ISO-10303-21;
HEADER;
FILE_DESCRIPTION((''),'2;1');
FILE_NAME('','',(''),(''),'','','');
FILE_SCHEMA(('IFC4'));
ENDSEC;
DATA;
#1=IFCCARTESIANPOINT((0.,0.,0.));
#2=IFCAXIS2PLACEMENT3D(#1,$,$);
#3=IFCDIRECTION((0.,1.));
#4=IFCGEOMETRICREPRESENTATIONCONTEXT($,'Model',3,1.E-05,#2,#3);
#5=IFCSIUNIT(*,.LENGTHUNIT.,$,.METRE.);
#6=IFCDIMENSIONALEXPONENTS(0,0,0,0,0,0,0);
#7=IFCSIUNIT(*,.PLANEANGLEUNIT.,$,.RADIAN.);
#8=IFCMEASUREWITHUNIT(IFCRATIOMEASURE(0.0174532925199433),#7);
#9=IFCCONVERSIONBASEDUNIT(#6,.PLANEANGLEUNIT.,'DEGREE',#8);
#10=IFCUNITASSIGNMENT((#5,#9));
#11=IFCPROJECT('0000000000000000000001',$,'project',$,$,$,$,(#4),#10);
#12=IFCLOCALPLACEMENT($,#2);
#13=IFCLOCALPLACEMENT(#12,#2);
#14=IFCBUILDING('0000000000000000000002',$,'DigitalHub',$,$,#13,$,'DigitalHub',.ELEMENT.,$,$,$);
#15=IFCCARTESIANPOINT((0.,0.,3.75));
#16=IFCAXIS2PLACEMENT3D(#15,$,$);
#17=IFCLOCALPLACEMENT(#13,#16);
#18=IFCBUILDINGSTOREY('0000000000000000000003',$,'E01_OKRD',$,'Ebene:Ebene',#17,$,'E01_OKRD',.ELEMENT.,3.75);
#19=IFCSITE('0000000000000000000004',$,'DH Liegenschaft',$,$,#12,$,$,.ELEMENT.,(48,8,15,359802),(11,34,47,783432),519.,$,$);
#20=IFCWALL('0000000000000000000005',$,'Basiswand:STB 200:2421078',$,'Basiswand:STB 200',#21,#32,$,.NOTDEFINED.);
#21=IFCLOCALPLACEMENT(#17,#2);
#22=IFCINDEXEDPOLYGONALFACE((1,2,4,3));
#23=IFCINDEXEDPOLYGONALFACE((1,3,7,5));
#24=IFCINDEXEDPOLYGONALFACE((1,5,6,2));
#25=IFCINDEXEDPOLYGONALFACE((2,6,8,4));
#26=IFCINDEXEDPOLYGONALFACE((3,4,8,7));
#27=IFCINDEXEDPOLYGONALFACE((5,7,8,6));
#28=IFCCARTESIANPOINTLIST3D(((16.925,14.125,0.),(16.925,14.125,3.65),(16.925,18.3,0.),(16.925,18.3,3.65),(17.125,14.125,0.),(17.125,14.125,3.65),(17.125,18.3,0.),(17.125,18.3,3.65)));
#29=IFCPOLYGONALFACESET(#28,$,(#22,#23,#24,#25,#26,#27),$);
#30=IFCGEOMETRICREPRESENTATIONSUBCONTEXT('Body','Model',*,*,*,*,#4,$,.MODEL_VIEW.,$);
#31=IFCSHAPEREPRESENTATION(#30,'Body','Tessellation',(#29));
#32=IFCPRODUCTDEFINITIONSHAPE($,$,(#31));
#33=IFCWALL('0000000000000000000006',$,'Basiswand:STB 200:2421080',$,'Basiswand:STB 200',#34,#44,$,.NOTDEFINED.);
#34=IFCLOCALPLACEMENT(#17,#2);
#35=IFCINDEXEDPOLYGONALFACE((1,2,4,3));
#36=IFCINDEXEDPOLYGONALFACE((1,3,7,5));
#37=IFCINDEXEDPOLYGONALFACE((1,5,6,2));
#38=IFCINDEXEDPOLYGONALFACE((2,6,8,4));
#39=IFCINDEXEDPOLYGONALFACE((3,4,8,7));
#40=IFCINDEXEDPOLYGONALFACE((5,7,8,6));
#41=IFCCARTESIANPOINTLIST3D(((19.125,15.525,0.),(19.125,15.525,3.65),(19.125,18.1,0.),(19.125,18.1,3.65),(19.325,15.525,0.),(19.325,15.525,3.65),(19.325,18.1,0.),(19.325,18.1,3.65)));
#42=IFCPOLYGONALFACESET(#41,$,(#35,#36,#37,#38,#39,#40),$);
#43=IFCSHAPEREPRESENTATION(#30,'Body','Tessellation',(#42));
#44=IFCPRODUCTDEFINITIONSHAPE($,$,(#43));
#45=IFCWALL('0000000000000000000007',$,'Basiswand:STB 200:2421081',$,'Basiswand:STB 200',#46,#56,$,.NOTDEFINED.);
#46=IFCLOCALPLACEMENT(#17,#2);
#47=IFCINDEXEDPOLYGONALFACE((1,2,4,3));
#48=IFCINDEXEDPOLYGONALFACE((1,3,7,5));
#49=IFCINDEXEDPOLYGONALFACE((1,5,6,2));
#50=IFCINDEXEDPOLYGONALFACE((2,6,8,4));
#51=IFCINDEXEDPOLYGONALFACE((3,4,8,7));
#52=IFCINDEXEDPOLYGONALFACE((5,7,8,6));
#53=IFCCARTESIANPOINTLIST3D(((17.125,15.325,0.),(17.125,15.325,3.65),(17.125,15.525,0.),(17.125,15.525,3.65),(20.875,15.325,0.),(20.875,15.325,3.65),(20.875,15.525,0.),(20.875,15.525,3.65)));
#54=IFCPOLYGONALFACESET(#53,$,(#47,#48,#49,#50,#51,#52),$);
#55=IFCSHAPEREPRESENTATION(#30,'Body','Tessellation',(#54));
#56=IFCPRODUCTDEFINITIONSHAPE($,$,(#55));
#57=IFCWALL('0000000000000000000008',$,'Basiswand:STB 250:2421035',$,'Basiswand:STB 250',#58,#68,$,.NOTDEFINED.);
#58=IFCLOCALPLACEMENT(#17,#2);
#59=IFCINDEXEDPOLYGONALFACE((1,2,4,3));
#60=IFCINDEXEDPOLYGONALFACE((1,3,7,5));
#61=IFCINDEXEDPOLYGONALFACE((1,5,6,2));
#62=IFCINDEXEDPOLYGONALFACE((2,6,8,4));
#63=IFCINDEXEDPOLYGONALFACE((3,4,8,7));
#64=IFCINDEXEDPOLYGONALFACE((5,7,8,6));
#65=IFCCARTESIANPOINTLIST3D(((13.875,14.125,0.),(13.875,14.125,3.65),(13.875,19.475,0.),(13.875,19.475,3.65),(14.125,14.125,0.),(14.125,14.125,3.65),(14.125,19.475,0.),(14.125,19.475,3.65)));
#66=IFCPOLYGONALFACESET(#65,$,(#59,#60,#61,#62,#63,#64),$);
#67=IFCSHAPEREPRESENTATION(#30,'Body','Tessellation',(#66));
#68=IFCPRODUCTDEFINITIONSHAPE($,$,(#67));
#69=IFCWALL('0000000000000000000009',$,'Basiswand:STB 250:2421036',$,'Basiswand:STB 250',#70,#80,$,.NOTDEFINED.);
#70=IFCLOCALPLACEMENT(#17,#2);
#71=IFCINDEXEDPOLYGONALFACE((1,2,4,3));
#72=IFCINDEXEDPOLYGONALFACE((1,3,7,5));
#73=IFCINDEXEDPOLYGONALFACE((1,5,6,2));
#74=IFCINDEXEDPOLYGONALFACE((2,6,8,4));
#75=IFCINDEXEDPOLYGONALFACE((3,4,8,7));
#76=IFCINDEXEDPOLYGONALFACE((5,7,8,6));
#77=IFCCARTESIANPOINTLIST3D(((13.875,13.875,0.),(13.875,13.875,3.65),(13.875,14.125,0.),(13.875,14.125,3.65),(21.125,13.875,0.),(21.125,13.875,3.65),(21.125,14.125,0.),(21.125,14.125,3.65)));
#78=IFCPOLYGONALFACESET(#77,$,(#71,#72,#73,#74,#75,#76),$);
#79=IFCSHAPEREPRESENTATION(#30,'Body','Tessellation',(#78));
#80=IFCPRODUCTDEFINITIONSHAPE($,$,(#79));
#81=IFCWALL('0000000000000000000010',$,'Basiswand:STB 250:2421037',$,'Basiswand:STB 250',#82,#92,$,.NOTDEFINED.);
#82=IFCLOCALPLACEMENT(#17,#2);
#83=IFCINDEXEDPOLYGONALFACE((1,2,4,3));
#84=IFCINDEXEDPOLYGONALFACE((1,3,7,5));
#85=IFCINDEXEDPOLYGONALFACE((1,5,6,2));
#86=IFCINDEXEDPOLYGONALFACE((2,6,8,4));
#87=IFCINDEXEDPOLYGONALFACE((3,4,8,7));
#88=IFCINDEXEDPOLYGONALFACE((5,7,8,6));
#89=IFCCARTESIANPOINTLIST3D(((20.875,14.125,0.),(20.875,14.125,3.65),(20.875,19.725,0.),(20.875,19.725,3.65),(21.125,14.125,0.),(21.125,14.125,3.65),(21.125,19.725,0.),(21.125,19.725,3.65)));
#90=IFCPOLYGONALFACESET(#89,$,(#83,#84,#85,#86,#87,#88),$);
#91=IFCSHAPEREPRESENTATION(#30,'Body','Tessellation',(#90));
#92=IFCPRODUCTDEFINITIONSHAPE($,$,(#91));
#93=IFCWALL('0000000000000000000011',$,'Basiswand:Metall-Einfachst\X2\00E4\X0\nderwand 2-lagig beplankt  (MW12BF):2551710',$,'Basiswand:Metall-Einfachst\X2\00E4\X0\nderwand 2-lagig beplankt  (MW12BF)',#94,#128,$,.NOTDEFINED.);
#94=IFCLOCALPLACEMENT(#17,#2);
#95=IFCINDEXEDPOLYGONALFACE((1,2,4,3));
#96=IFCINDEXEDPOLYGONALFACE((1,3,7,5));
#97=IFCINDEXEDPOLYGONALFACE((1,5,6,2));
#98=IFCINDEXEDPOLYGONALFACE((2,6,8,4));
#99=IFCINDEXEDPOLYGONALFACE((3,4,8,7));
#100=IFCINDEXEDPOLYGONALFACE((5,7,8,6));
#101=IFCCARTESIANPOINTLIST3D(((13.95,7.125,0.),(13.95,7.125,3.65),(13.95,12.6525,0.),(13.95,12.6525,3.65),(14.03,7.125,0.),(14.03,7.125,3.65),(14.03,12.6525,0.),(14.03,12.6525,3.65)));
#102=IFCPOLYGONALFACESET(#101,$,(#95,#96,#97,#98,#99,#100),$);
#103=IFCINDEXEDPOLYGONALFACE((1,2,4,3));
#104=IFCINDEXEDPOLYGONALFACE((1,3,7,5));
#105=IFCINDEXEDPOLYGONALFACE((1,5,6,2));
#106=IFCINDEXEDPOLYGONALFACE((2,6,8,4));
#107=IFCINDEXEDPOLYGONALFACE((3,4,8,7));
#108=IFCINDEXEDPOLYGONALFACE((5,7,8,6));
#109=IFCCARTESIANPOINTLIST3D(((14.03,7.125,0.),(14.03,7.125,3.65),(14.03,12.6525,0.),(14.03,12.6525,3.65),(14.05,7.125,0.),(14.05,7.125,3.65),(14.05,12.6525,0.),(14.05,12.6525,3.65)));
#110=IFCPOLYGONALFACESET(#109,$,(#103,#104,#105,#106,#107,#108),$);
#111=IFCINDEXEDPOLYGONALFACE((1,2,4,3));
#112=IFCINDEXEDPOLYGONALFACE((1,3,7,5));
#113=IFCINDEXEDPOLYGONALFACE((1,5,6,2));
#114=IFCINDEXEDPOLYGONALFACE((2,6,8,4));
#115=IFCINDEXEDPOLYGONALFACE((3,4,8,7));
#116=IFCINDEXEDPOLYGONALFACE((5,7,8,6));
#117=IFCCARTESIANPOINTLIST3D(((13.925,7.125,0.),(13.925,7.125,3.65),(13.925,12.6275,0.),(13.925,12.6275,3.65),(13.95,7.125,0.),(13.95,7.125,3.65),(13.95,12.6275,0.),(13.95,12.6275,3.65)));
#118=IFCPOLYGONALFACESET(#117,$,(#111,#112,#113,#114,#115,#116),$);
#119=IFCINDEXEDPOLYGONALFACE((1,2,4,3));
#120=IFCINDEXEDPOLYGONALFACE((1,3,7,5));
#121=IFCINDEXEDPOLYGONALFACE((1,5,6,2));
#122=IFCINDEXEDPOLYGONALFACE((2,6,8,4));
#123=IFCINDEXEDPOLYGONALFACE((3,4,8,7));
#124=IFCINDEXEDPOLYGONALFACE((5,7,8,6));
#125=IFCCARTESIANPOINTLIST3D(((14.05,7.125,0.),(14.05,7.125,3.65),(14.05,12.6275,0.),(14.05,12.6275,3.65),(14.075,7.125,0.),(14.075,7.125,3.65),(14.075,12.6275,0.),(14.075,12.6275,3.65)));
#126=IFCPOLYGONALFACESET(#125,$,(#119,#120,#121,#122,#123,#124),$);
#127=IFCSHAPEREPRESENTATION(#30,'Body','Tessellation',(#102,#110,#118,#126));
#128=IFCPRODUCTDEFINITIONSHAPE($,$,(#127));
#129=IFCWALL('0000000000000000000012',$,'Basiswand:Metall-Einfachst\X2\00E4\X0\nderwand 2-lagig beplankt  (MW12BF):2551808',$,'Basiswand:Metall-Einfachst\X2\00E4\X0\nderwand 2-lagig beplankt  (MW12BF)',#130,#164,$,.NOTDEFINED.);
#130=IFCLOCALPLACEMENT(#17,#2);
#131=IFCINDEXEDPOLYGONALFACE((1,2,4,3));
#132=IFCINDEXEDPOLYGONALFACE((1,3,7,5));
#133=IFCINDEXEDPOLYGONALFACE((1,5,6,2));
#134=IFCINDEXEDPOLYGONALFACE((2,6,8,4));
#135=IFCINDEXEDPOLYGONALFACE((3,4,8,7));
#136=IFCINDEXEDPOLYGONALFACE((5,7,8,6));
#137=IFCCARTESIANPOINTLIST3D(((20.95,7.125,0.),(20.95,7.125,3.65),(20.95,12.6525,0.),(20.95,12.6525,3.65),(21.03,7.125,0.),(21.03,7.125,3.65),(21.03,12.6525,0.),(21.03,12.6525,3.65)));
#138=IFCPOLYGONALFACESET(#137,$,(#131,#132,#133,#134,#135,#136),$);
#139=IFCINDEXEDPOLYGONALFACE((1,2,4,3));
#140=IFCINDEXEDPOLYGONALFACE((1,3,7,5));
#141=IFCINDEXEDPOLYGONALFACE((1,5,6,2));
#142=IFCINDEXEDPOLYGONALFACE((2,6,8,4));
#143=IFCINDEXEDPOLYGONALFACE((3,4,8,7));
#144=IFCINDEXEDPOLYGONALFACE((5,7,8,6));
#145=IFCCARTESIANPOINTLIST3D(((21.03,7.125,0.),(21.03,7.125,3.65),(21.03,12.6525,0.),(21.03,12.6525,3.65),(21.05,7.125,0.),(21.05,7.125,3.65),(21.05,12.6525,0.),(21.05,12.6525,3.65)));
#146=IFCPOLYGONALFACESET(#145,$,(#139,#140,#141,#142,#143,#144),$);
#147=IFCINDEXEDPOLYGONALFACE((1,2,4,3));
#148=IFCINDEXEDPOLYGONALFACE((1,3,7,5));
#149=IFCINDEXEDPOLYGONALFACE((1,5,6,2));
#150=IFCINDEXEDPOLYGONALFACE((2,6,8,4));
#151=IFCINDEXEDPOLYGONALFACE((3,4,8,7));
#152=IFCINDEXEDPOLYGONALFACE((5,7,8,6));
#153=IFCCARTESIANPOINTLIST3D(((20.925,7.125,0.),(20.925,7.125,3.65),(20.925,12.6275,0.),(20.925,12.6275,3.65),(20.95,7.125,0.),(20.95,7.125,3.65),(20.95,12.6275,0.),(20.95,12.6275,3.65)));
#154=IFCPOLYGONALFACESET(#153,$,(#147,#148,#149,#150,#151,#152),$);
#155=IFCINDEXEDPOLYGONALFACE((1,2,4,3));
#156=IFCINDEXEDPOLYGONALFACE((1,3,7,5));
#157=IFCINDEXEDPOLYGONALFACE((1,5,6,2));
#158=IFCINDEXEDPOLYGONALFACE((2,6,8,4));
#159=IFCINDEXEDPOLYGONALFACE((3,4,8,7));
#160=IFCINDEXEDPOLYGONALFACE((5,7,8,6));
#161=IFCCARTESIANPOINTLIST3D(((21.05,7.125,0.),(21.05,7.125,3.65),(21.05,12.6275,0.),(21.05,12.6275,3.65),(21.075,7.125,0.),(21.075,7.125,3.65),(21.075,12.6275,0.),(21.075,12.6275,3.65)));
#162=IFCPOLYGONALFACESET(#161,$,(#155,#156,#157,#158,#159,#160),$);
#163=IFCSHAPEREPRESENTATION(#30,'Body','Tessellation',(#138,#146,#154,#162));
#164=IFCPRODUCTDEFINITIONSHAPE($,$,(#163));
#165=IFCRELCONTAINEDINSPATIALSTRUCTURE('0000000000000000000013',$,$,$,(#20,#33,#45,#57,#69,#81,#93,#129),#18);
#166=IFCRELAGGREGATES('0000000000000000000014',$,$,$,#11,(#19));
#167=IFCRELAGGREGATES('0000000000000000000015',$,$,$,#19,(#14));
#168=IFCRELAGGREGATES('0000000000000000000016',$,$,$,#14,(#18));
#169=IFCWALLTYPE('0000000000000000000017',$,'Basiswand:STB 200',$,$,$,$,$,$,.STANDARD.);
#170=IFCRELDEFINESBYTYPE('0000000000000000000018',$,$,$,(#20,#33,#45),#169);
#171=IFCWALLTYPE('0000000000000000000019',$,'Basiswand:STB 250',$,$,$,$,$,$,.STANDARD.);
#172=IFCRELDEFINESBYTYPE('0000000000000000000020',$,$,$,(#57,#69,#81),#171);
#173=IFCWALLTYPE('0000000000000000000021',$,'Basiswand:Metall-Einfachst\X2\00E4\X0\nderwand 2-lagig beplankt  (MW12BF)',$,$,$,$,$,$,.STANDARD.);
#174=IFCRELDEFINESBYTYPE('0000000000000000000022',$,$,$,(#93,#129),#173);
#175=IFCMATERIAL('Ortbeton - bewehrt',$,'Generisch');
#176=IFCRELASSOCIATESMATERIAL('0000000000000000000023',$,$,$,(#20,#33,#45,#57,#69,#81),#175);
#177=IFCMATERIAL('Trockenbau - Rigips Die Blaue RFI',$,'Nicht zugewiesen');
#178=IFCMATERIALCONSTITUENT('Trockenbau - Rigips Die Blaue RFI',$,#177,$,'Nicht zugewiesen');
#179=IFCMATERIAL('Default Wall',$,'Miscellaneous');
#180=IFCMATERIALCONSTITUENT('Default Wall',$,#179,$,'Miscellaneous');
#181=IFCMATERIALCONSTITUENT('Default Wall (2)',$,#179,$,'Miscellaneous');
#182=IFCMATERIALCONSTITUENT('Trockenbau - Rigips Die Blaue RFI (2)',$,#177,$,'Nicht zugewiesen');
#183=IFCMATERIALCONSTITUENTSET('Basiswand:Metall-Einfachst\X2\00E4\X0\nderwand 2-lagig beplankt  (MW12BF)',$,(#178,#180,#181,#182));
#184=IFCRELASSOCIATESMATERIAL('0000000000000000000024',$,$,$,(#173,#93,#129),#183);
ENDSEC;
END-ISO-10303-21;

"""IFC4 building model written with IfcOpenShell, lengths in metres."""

from ifc_helpers import new_model, entity, si_unit, converted_unit, direction, frame, origin, place, context, subcontext, project, spatial, indexed_curve, outline, extrude, material, constituent, constituent_set, type_object, element, save


model = new_model("IFC4")

# Units and contexts
model_context = context("Model", 3, precision=1e-05, world=origin(), true_north=direction((0.0, 1.0)))
body_context = subcontext(model_context, "Body", "Model", "MODEL_VIEW")
ifc_project = project(units=[si_unit("LENGTHUNIT", "METRE"), converted_unit("PLANEANGLEUNIT", "DEGREE", entity("IfcRatioMeasure", 0.0174532925199433), si_unit("PLANEANGLEUNIT", "RADIAN"), dimensions=[0, 0, 0, 0, 0, 0, 0])], contexts=[model_context])

# Site, building, storey
site_placement = place(None, frame((0.0, 0.0, 0.0)))
site = spatial("IfcSite", under=ifc_project, at=site_placement, Name="DH Liegenschaft", CompositionType="ELEMENT", RefLatitude=(48, 8, 15, 359802), RefLongitude=(11, 34, 47, 783432), RefElevation=519.0)
building_placement = place(site_placement, origin())
building = spatial("IfcBuilding", under=site, at=building_placement, Name="DigitalHub", LongName="DigitalHub", CompositionType="ELEMENT")
storey_placement = place(building_placement, frame((0.0, 0.0, 3.75)))
storey = spatial("IfcBuildingStorey", under=building, at=storey_placement, Name="E01_OKRD", ObjectType="Ebene:Ebene", LongName="E01_OKRD", CompositionType="ELEMENT", Elevation=3.75)

# Walls
ifc_material_1 = material(Name="Ortbeton - bewehrt", Category="Generisch")
wall_type_1 = type_object("IfcWallType", Name="Basiswand:STB 200", PredefinedType="STANDARD")
wall_1_placement = place(storey_placement, frame((17.025, 14.125, 0.0), z_axis=(0.0, 0.0, 1.0), x_axis=(0.0, 1.0, 0.0)))
element("IfcWall", 1, at=wall_1_placement, inside=storey, type_object=wall_type_1, material=ifc_material_1, Name="Basiswand:STB 200:2421078", ObjectType="Basiswand:STB 200", PredefinedType="NOTDEFINED", context=body_context, shape_type="SweptSolid", body=[
    extrude(outline(indexed_curve([(4.175, 0.1), (0.0, 0.1), (0.0, -0.1), (4.175, -0.1), (4.175, 0.1)], self_intersect=False)), origin(), (0.0, 0.0, 1.0), 3.65),
])
wall_2_placement = place(storey_placement, frame((19.225, 18.1, 0.0), z_axis=(0.0, 0.0, 1.0), x_axis=(0.0, -1.0, 0.0)))
element("IfcWall", 2, at=wall_2_placement, inside=storey, type_object=wall_type_1, material=ifc_material_1, Name="Basiswand:STB 200:2421080", ObjectType="Basiswand:STB 200", PredefinedType="NOTDEFINED", context=body_context, shape_type="SweptSolid", body=[
    extrude(outline(indexed_curve([(2.575, 0.1), (0.0, 0.1), (0.0, -0.1), (2.575, -0.1), (2.575, 0.1)], self_intersect=False)), origin(), (0.0, 0.0, 1.0), 3.65),
])
wall_3_placement = place(storey_placement, frame((20.875, 15.425, 0.0), z_axis=(0.0, 0.0, 1.0), x_axis=(-1.0, 0.0, 0.0)))
element("IfcWall", 3, at=wall_3_placement, inside=storey, type_object=wall_type_1, material=ifc_material_1, Name="Basiswand:STB 200:2421081", ObjectType="Basiswand:STB 200", PredefinedType="NOTDEFINED", context=body_context, shape_type="SweptSolid", body=[
    extrude(outline(indexed_curve([(3.75, 0.1), (0.0, 0.1), (0.0, -0.1), (3.75, -0.1), (3.75, 0.1)], self_intersect=False)), origin(), (0.0, 0.0, 1.0), 3.65),
])
wall_type_2 = type_object("IfcWallType", Name="Basiswand:STB 250", PredefinedType="STANDARD")
wall_4_placement = place(storey_placement, frame((14.0, 14.125, 0.0), z_axis=(0.0, 0.0, 1.0), x_axis=(0.0, 1.0, 0.0)))
element("IfcWall", 4, at=wall_4_placement, inside=storey, type_object=wall_type_2, material=ifc_material_1, Name="Basiswand:STB 250:2421035", ObjectType="Basiswand:STB 250", PredefinedType="NOTDEFINED", context=body_context, shape_type="SweptSolid", body=[
    extrude(outline(indexed_curve([(5.35, 0.125), (0.0, 0.125), (0.0, -0.125), (5.35, -0.125), (5.35, 0.125)], self_intersect=False)), origin(), (0.0, 0.0, 1.0), 3.65),
])
wall_5_placement = place(storey_placement, frame((13.875, 14.0, 0.0)))
element("IfcWall", 5, at=wall_5_placement, inside=storey, type_object=wall_type_2, material=ifc_material_1, Name="Basiswand:STB 250:2421036", ObjectType="Basiswand:STB 250", PredefinedType="NOTDEFINED", context=body_context, shape_type="SweptSolid", body=[
    extrude(outline(indexed_curve([(7.25, 0.125), (0.0, 0.125), (0.0, -0.125), (7.25, -0.125), (7.25, 0.125)], self_intersect=False)), origin(), (0.0, 0.0, 1.0), 3.65),
])
wall_6_placement = place(storey_placement, frame((21.0, 14.125, 0.0), z_axis=(0.0, 0.0, 1.0), x_axis=(0.0, 1.0, 0.0)))
element("IfcWall", 6, at=wall_6_placement, inside=storey, type_object=wall_type_2, material=ifc_material_1, Name="Basiswand:STB 250:2421037", ObjectType="Basiswand:STB 250", PredefinedType="NOTDEFINED", context=body_context, shape_type="SweptSolid", body=[
    extrude(outline(indexed_curve([(5.6, 0.125), (0.0, 0.125), (0.0, -0.125), (5.6, -0.125), (5.6, 0.125)], self_intersect=False)), origin(), (0.0, 0.0, 1.0), 3.65),
])
ifc_material_2 = material(Name="Trockenbau - Rigips Die Blaue RFI", Category="Nicht zugewiesen")
ifc_constituent_1 = constituent(ifc_material_2, Name="Trockenbau - Rigips Die Blaue RFI", Category="Nicht zugewiesen")
ifc_material_3 = material(Name="Default Wall", Category="Miscellaneous")
ifc_constituent_2 = constituent(ifc_material_3, Name="Default Wall", Category="Miscellaneous")
ifc_constituent_3 = constituent(ifc_material_3, Name="Default Wall (2)", Category="Miscellaneous")
ifc_constituent_4 = constituent(ifc_material_2, Name="Trockenbau - Rigips Die Blaue RFI (2)", Category="Nicht zugewiesen")
ifc_constituent_set_1 = constituent_set(constituents=[ifc_constituent_1, ifc_constituent_2, ifc_constituent_3, ifc_constituent_4], Name="Basiswand:Metall-Einfachständerwand 2-lagig beplankt  (MW12BF)")
wall_type_3 = type_object("IfcWallType", Name="Basiswand:Metall-Einfachständerwand 2-lagig beplankt  (MW12BF)", PredefinedType="STANDARD", material=ifc_constituent_set_1)
wall_7_placement = place(storey_placement, frame((14.0, 7.125, 0.0), z_axis=(0.0, 0.0, 1.0), x_axis=(0.0, 1.0, 0.0)))
element("IfcWall", 7, at=wall_7_placement, inside=storey, type_object=wall_type_3, material=ifc_constituent_set_1, Name="Basiswand:Metall-Einfachständerwand 2-lagig beplankt  (MW12BF):2551710", ObjectType="Basiswand:Metall-Einfachständerwand 2-lagig beplankt  (MW12BF)", PredefinedType="NOTDEFINED", context=body_context, shape_type="SweptSolid", body=[
    extrude(outline(indexed_curve([(-2.7638, -0.04), (2.7638, -0.04), (2.7638, 0.04), (-2.7638, 0.04), (-2.7638, -0.04)], self_intersect=False)), frame((2.7638, 0.01, 0.0)), (0.0, 0.0, 1.0), 3.65),
    extrude(outline(indexed_curve([(-2.7638, -0.01), (2.7638, -0.01), (2.7638, 0.01), (-2.7638, 0.01), (-2.7638, -0.01)], self_intersect=False)), frame((2.7638, -0.04, 0.0)), (0.0, 0.0, 1.0), 3.65),
    extrude(outline(indexed_curve([(-0.0125, -2.7513), (0.0125, -2.7513), (0.0125, 2.7513), (-0.0125, 2.7513), (-0.0125, -2.7513)], self_intersect=False)), frame((2.7513, 0.0625, 0.0), z_axis=(0.0, 0.0, 1.0), x_axis=(0.0, -1.0, 0.0)), (0.0, 0.0, 1.0), 3.65),
    extrude(outline(indexed_curve([(-0.0125, -2.7513), (0.0125, -2.7513), (0.0125, 2.7513), (-0.0125, 2.7513), (-0.0125, -2.7513)], self_intersect=False)), frame((2.7513, -0.0625, 0.0), z_axis=(0.0, 0.0, 1.0), x_axis=(0.0, 1.0, 0.0)), (0.0, 0.0, 1.0), 3.65),
])
wall_8_placement = place(storey_placement, frame((21.0, 7.125, 0.0), z_axis=(0.0, 0.0, 1.0), x_axis=(0.0, 1.0, 0.0)))
element("IfcWall", 8, at=wall_8_placement, inside=storey, type_object=wall_type_3, material=ifc_constituent_set_1, Name="Basiswand:Metall-Einfachständerwand 2-lagig beplankt  (MW12BF):2551808", ObjectType="Basiswand:Metall-Einfachständerwand 2-lagig beplankt  (MW12BF)", PredefinedType="NOTDEFINED", context=body_context, shape_type="SweptSolid", body=[
    extrude(outline(indexed_curve([(-2.7638, -0.04), (2.7638, -0.04), (2.7638, 0.04), (-2.7638, 0.04), (-2.7638, -0.04)], self_intersect=False)), frame((2.7638, 0.01, 0.0)), (0.0, 0.0, 1.0), 3.65),
    extrude(outline(indexed_curve([(-2.7638, -0.01), (2.7638, -0.01), (2.7638, 0.01), (-2.7638, 0.01), (-2.7638, -0.01)], self_intersect=False)), frame((2.7638, -0.04, 0.0)), (0.0, 0.0, 1.0), 3.65),
    extrude(outline(indexed_curve([(-0.0125, -2.7513), (0.0125, -2.7513), (0.0125, 2.7513), (-0.0125, 2.7513), (-0.0125, -2.7513)], self_intersect=False)), frame((2.7513, 0.0625, 0.0), z_axis=(0.0, 0.0, 1.0), x_axis=(0.0, -1.0, 0.0)), (0.0, 0.0, 1.0), 3.65),
    extrude(outline(indexed_curve([(-0.0125, -2.7513), (0.0125, -2.7513), (0.0125, 2.7513), (-0.0125, 2.7513), (-0.0125, -2.7513)], self_intersect=False)), frame((2.7513, -0.0625, 0.0), z_axis=(0.0, 0.0, 1.0), x_axis=(0.0, 1.0, 0.0)), (0.0, 0.0, 1.0), 3.65),
])

save(model, "model.ifc")
